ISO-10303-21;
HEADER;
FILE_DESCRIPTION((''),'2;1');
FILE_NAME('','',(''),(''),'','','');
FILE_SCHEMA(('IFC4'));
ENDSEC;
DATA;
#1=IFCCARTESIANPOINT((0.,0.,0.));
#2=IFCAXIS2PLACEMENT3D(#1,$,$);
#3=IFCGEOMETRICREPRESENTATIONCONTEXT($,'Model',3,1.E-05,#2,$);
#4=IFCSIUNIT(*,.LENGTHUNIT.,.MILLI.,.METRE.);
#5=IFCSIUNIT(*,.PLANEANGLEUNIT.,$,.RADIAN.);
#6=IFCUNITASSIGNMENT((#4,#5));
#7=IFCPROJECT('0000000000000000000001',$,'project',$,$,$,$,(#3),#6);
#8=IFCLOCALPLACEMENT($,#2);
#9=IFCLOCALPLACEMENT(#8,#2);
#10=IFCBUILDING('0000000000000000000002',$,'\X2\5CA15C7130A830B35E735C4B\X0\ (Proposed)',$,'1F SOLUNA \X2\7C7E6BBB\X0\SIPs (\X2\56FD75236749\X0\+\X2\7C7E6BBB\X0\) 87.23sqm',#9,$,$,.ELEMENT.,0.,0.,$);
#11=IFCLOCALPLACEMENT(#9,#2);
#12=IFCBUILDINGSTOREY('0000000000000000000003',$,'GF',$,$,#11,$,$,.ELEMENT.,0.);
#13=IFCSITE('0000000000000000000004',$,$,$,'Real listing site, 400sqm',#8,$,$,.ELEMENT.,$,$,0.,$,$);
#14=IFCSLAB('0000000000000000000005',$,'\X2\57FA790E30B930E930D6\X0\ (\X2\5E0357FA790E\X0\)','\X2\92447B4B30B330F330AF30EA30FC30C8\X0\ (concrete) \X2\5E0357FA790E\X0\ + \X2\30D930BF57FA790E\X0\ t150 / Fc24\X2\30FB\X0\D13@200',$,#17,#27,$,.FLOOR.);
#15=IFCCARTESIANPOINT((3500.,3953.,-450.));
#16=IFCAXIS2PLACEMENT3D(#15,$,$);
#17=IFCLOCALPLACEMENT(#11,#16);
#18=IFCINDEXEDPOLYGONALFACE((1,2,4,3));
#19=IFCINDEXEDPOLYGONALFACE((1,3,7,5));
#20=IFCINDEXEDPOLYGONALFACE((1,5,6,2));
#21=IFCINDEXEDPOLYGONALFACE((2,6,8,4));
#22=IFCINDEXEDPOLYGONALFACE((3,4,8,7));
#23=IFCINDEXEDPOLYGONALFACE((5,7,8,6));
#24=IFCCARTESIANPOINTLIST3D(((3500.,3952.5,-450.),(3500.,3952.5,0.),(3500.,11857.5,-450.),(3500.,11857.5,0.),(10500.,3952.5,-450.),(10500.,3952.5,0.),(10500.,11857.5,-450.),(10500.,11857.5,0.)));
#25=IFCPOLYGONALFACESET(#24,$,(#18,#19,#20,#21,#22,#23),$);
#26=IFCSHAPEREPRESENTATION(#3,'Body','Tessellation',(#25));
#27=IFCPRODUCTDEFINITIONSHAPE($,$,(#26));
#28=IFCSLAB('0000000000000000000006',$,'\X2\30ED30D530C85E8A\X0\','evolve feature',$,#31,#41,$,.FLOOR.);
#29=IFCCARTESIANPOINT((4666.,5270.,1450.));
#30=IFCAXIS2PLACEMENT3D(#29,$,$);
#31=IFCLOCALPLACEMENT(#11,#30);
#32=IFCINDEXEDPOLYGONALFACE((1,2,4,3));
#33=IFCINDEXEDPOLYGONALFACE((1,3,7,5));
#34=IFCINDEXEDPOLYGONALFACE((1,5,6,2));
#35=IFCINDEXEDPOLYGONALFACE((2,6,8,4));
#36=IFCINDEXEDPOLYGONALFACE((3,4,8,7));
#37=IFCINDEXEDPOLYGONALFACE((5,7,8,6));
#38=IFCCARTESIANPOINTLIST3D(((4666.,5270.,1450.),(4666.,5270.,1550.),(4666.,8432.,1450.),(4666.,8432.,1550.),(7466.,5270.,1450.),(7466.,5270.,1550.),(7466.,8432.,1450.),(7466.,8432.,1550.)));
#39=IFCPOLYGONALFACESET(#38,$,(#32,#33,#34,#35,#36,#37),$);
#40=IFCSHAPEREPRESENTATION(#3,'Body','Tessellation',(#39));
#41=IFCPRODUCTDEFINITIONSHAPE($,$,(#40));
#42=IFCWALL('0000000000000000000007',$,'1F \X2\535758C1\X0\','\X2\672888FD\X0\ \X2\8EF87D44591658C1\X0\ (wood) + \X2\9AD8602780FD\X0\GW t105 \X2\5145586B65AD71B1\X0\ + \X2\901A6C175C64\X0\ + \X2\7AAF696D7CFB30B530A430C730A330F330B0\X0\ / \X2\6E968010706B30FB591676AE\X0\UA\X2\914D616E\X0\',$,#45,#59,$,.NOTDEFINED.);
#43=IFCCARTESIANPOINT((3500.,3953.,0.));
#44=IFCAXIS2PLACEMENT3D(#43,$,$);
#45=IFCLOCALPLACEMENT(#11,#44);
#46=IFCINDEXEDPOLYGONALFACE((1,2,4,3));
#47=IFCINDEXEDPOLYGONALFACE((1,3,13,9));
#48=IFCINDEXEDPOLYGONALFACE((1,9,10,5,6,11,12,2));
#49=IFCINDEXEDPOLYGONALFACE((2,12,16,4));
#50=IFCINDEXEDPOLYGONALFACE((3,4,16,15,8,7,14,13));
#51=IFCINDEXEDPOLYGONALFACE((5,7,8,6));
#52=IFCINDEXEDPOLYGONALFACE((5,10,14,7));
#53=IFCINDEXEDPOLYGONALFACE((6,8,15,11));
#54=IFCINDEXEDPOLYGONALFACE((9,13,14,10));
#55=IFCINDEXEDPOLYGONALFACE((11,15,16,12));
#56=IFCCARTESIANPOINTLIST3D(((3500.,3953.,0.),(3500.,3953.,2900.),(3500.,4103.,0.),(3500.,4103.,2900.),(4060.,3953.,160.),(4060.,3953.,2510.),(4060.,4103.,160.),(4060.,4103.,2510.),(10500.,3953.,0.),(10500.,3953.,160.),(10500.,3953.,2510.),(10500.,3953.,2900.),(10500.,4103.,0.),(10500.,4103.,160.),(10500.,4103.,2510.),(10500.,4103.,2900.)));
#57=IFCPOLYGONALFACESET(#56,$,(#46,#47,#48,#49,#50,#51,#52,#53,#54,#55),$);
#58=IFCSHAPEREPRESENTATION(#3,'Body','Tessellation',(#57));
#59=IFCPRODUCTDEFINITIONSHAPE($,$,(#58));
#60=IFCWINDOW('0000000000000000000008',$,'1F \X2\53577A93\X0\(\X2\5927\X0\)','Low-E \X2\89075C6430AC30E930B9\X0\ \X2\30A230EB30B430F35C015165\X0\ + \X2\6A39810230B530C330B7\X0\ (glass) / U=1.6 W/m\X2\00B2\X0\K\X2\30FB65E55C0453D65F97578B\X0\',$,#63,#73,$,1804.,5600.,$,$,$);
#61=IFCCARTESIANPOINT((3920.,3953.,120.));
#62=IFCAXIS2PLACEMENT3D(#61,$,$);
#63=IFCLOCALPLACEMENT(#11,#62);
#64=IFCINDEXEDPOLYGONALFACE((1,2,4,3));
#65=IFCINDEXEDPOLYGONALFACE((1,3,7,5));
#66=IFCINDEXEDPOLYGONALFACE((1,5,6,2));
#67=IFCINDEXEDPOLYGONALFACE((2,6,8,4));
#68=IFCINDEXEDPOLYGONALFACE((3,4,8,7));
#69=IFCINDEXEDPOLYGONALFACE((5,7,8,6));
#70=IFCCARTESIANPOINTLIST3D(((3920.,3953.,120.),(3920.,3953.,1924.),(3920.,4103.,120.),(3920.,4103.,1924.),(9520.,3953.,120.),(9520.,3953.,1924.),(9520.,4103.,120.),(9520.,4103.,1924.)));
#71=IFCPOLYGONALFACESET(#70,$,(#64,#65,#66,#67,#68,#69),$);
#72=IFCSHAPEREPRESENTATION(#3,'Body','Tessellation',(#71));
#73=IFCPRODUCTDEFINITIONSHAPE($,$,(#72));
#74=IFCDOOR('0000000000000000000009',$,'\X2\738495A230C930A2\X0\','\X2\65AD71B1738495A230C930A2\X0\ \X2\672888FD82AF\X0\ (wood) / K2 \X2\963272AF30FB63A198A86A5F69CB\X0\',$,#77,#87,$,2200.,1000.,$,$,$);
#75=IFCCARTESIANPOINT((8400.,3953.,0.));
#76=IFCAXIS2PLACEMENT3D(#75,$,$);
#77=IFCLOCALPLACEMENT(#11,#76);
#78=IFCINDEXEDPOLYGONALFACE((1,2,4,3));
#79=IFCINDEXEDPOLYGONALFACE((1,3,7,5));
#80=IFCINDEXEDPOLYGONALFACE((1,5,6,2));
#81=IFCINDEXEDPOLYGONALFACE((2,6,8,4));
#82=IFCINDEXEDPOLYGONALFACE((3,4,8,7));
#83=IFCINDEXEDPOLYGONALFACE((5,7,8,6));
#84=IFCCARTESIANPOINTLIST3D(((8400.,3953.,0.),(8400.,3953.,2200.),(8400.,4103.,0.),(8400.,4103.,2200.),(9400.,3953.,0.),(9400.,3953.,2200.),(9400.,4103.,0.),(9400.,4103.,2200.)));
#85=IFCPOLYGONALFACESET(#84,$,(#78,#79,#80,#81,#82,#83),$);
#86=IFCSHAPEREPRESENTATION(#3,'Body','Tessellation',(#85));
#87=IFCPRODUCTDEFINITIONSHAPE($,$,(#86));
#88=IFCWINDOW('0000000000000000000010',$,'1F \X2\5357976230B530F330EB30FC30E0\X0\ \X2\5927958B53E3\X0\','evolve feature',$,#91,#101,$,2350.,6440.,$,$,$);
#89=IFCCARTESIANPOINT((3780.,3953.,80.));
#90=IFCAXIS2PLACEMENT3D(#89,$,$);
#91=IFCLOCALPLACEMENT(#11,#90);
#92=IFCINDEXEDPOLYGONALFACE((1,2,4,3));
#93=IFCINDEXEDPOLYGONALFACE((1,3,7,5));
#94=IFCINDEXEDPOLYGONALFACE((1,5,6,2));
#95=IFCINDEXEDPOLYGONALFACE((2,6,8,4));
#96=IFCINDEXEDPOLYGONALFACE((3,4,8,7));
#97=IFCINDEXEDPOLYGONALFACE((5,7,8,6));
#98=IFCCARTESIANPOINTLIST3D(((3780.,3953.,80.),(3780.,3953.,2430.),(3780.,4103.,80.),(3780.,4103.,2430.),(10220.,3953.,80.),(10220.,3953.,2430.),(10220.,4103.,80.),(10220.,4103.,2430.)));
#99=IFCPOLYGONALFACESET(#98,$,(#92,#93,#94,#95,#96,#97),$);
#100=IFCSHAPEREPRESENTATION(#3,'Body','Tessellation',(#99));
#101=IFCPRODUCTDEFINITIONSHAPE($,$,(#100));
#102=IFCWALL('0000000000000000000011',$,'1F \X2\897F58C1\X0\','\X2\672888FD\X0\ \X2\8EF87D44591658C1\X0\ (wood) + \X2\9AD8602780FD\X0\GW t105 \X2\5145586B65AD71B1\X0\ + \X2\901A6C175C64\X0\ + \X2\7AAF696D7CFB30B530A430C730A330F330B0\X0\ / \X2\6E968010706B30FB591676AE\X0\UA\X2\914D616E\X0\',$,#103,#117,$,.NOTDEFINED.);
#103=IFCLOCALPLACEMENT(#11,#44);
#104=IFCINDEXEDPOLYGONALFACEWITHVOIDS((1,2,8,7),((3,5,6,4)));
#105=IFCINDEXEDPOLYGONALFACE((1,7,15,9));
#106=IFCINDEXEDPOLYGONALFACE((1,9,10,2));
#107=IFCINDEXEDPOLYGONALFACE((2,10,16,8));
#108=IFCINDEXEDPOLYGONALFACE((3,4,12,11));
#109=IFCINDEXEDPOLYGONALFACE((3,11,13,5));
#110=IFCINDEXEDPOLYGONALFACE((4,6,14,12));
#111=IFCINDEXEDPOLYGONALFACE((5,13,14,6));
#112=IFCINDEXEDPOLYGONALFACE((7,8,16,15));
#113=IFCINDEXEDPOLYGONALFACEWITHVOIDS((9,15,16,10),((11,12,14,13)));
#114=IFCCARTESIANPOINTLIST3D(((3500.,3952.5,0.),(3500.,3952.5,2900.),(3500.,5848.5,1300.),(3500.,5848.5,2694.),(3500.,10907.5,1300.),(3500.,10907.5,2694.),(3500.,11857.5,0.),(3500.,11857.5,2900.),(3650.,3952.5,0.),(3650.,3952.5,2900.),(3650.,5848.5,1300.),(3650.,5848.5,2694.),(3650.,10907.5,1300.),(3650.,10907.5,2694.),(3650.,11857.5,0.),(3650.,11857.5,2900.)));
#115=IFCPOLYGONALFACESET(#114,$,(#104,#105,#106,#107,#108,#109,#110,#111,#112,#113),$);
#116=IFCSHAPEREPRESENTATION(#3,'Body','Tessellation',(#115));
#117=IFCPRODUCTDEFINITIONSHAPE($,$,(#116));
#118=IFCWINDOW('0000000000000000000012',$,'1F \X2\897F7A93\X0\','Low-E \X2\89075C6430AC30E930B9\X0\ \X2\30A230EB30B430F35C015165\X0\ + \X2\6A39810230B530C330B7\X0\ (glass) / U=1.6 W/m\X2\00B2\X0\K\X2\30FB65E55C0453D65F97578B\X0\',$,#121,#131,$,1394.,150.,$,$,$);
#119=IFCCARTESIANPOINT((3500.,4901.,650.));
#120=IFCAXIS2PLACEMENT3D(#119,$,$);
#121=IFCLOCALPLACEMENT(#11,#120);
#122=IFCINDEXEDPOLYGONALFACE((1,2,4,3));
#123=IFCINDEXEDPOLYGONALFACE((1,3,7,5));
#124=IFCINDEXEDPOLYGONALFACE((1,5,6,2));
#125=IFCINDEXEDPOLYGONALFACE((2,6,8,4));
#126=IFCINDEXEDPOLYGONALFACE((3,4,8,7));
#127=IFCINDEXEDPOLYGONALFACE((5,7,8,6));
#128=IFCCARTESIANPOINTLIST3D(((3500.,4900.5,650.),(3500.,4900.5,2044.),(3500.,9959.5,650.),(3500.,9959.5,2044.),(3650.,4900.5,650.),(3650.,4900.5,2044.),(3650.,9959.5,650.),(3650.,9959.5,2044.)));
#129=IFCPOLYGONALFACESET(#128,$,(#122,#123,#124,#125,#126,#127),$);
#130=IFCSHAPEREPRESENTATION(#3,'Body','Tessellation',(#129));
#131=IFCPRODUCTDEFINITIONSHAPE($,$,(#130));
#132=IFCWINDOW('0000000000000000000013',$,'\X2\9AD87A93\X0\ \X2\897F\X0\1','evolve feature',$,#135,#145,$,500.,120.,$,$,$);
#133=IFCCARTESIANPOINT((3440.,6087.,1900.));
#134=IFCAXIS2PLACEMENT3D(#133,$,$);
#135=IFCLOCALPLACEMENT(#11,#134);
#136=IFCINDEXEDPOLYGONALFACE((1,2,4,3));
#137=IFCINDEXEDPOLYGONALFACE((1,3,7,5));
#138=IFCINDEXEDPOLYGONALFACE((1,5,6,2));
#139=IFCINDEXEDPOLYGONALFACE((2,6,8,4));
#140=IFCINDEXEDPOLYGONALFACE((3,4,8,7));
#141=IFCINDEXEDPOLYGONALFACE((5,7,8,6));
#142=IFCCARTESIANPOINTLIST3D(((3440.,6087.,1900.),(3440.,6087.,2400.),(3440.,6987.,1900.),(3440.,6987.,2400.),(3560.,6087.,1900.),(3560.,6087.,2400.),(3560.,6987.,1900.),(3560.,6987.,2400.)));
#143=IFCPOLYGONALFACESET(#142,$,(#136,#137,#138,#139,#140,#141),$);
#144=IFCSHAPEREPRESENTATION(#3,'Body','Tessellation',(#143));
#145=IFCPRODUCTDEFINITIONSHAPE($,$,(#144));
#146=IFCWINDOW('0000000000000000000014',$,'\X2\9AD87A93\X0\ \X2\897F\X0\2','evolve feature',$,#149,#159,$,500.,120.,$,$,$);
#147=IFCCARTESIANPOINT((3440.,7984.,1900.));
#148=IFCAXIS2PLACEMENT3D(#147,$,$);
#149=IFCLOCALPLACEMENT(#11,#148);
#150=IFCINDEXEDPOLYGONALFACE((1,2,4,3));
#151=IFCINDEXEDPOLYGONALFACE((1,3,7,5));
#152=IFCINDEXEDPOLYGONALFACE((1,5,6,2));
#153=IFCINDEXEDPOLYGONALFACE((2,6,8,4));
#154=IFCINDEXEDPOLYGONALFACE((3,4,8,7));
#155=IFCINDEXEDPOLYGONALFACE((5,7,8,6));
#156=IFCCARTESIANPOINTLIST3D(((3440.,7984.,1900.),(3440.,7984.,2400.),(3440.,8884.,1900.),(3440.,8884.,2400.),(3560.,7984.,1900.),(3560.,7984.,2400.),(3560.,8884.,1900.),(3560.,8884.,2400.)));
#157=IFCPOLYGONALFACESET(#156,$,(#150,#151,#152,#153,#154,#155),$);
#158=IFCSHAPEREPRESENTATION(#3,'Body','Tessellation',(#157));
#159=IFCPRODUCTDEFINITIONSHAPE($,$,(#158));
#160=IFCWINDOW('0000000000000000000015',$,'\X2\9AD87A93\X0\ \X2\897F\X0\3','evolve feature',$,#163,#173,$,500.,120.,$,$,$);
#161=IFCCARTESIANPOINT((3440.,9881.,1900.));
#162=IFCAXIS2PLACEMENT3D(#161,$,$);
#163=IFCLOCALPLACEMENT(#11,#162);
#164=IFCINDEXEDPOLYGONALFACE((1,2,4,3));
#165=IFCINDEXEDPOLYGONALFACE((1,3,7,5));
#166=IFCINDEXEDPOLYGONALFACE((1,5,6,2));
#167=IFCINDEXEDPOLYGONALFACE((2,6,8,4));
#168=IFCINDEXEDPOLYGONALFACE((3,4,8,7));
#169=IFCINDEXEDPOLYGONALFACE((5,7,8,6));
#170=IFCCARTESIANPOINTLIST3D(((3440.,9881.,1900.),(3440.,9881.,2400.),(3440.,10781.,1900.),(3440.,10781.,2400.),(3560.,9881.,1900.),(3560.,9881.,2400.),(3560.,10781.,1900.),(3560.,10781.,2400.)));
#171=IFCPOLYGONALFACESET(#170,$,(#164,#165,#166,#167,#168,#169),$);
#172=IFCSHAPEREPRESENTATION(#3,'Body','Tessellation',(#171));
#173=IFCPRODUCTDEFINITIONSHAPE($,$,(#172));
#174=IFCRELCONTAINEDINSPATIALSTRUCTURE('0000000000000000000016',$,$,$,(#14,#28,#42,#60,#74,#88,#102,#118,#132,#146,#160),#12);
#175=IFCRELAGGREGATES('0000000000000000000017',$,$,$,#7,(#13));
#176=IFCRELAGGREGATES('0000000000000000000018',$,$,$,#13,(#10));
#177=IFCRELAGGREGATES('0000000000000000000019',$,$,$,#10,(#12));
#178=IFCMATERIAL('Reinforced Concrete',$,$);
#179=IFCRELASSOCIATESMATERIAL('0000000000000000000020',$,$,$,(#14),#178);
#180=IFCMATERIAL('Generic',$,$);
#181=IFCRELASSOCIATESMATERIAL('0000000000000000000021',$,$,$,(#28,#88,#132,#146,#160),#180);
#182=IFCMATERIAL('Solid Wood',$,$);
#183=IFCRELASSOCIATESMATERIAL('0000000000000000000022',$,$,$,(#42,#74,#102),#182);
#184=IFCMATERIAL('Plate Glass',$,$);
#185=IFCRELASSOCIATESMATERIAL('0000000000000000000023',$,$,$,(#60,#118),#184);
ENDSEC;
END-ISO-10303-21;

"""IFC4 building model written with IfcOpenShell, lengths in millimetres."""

from ifc_helpers import new_model, si_unit, frame, frame_2d, origin, place, context, project, spatial, rectangle, extrude, material, element, fill, save


model = new_model("IFC4")

# Units and contexts
model_context = context("Model", 3, precision=1e-05, world=origin())
ifc_project = project(units=[si_unit("LENGTHUNIT", "METRE", prefix="MILLI"), si_unit("PLANEANGLEUNIT", "RADIAN")], contexts=[model_context])

# Site, building, storey
site_placement = place(None, origin())
site = spatial("IfcSite", under=ifc_project, at=site_placement, ObjectType="Real listing site, 400sqm", CompositionType="ELEMENT", RefElevation=0.0)
building_placement = place(site_placement, origin())
building = spatial("IfcBuilding", under=site, at=building_placement, Name="岡山エコ平屋 (Proposed)", ObjectType="1F SOLUNA 籾殻SIPs (国産杉+籾殻) 87.23sqm", CompositionType="ELEMENT", ElevationOfRefHeight=0.0, ElevationOfTerrain=0.0)
storey_placement = place(building_placement, origin())
storey = spatial("IfcBuildingStorey", under=building, at=storey_placement, Name="GF", CompositionType="ELEMENT", Elevation=0.0)

# Slabs
ifc_material_1 = material(Name="Reinforced Concrete")
slab_1_placement = place(storey_placement, frame((3500.0, 3953.0, -450.0)))
element("IfcSlab", 1, at=slab_1_placement, inside=storey, material=ifc_material_1, Name="基礎スラブ (布基礎)", Description="鉄筋コンクリート (concrete) 布基礎 + ベタ基礎 t150 / Fc24・D13@200", PredefinedType="FLOOR", context=model_context, shape_type="SweptSolid", body=[
    extrude(rectangle(XDim=7000.0, YDim=7905.0, at=frame_2d((3500.0, 3952.0))), frame((3500.0, 3953.0, -450.0)), (0.0, 0.0, 1.0), 450.0),
])
ifc_material_2 = material(Name="Solid Wood")
ifc_material_3 = material(Name="Generic")
slab_2_placement = place(storey_placement, frame((4666.0, 5270.0, 1450.0)))
element("IfcSlab", 2, at=slab_2_placement, inside=storey, material=ifc_material_3, Name="ロフト床", Description="evolve feature", PredefinedType="FLOOR", context=model_context, shape_type="SweptSolid", body=[
    extrude(rectangle(XDim=2800.0, YDim=3162.0, at=frame_2d((1400.0, 1581.0))), frame((4666.0, 5270.0, 1450.0)), (0.0, 0.0, 1.0), 100.0),
])

# Wall, openings, windows, door
wall_1_placement = place(storey_placement, frame((3500.0, 3953.0, 0.0)))
wall_1 = element("IfcWall", 3, at=wall_1_placement, inside=storey, material=ifc_material_2, Name="1F 南壁", Description="木製 軸組外壁 (wood) + 高性能GW t105 充填断熱 + 通気層 + 窯業系サイディング / 準耐火・外皮UA配慮", PredefinedType="NOTDEFINED", context=model_context, shape_type="SweptSolid", body=[
    extrude(rectangle(XDim=7000.0, YDim=150.0, at=frame_2d((3500.0, 75.0))), frame((3500.0, 3953.0, 0.0)), (0.0, 0.0, 1.0), 2900.0),
])
opening_1_placement = place(storey_placement, frame((3920.0, 3953.0, 120.0)))
opening_1 = element("IfcOpeningElement", 4, at=opening_1_placement, cuts=wall_1, PredefinedType="NOTDEFINED", context=model_context, shape_type="SweptSolid", body=[
    extrude(rectangle(XDim=5600.0, YDim=150.0, at=frame_2d((2800.0, 75.0))), frame((3920.0, 3953.0, 120.0)), (0.0, 0.0, 1.0), 1804.0),
])
opening_2_placement = place(storey_placement, frame((8400.0, 3953.0, 0.0)))
opening_2 = element("IfcOpeningElement", 5, at=opening_2_placement, cuts=wall_1, PredefinedType="NOTDEFINED", context=model_context, shape_type="SweptSolid", body=[
    extrude(rectangle(XDim=1000.0, YDim=150.0, at=frame_2d((500.0, 75.0))), frame((8400.0, 3953.0, 0.0)), (0.0, 0.0, 1.0), 2200.0),
])
opening_3_placement = place(storey_placement, frame((3780.0, 3953.0, 80.0)))
opening_3 = element("IfcOpeningElement", 6, at=opening_3_placement, cuts=wall_1, PredefinedType="NOTDEFINED", context=model_context, shape_type="SweptSolid", body=[
    extrude(rectangle(XDim=6440.0, YDim=150.0, at=frame_2d((3220.0, 75.0))), frame((3780.0, 3953.0, 80.0)), (0.0, 0.0, 1.0), 2350.0),
])
ifc_material_4 = material(Name="Plate Glass")
window_1_placement = place(storey_placement, frame((3920.0, 3953.0, 120.0)))
window_1 = element("IfcWindow", 7, at=window_1_placement, inside=storey, material=ifc_material_4, Name="1F 南窓(大)", Description="Low-E 複層ガラス アルゴン封入 + 樹脂サッシ (glass) / U=1.6 W/m²K・日射取得型", OverallHeight=1804.0, OverallWidth=5600.0, context=model_context, shape_type="SweptSolid", body=[
    extrude(rectangle(XDim=5600.0, YDim=150.0, at=frame_2d((2800.0, 75.0))), frame((3920.0, 3953.0, 120.0)), (0.0, 0.0, 1.0), 1804.0),
])
fill(opening_1, window_1)
door_placement = place(storey_placement, frame((8400.0, 3953.0, 0.0)))
door = element("IfcDoor", 8, at=door_placement, inside=storey, material=ifc_material_2, Name="玄関ドア", Description="断熱玄関ドア 木製芯 (wood) / K2 防犯・採風機構", OverallHeight=2200.0, OverallWidth=1000.0, context=model_context, shape_type="SweptSolid", body=[
    extrude(rectangle(XDim=1000.0, YDim=150.0, at=frame_2d((500.0, 75.0))), frame((8400.0, 3953.0, 0.0)), (0.0, 0.0, 1.0), 2200.0),
])
fill(opening_2, door)
window_2_placement = place(storey_placement, frame((3780.0, 3953.0, 80.0)))
window_2 = element("IfcWindow", 9, at=window_2_placement, inside=storey, material=ifc_material_3, Name="1F 南面サンルーム 大開口", Description="evolve feature", OverallHeight=2350.0, OverallWidth=6440.0, context=model_context, shape_type="SweptSolid", body=[
    extrude(rectangle(XDim=6440.0, YDim=150.0, at=frame_2d((3220.0, 75.0))), frame((3780.0, 3953.0, 80.0)), (0.0, 0.0, 1.0), 2350.0),
])
fill(opening_3, window_2)

# Wall, openings, windows
wall_2_placement = place(storey_placement, frame((3500.0, 3953.0, 0.0)))
wall_2 = element("IfcWall", 10, at=wall_2_placement, inside=storey, material=ifc_material_2, Name="1F 西壁", Description="木製 軸組外壁 (wood) + 高性能GW t105 充填断熱 + 通気層 + 窯業系サイディング / 準耐火・外皮UA配慮", PredefinedType="NOTDEFINED", context=model_context, shape_type="SweptSolid", body=[
    extrude(rectangle(XDim=150.0, YDim=7905.0, at=frame_2d((75.0, 3952.0))), frame((3500.0, 3953.0, 0.0)), (0.0, 0.0, 1.0), 2900.0),
])
opening_4_placement = place(storey_placement, frame((3500.0, 4901.0, 650.0)))
opening_4 = element("IfcOpeningElement", 11, at=opening_4_placement, cuts=wall_2, PredefinedType="NOTDEFINED", context=model_context, shape_type="SweptSolid", body=[
    extrude(rectangle(XDim=150.0, YDim=5059.0, at=frame_2d((75.0, 2529.0))), frame((3500.0, 4901.0, 650.0)), (0.0, 0.0, 1.0), 1394.0),
])
opening_5_placement = place(storey_placement, frame((3440.0, 6087.0, 1900.0)))
opening_5 = element("IfcOpeningElement", 12, at=opening_5_placement, cuts=wall_2, PredefinedType="NOTDEFINED", context=model_context, shape_type="SweptSolid", body=[
    extrude(rectangle(XDim=120.0, YDim=900.0, at=frame_2d((60.0, 450.0))), frame((3440.0, 6087.0, 1900.0)), (0.0, 0.0, 1.0), 500.0),
])
opening_6_placement = place(storey_placement, frame((3440.0, 7984.0, 1900.0)))
opening_6 = element("IfcOpeningElement", 13, at=opening_6_placement, cuts=wall_2, PredefinedType="NOTDEFINED", context=model_context, shape_type="SweptSolid", body=[
    extrude(rectangle(XDim=120.0, YDim=900.0, at=frame_2d((60.0, 450.0))), frame((3440.0, 7984.0, 1900.0)), (0.0, 0.0, 1.0), 500.0),
])
opening_7_placement = place(storey_placement, frame((3440.0, 9881.0, 1900.0)))
opening_7 = element("IfcOpeningElement", 14, at=opening_7_placement, cuts=wall_2, PredefinedType="NOTDEFINED", context=model_context, shape_type="SweptSolid", body=[
    extrude(rectangle(XDim=120.0, YDim=900.0, at=frame_2d((60.0, 450.0))), frame((3440.0, 9881.0, 1900.0)), (0.0, 0.0, 1.0), 500.0),
])
window_3_placement = place(storey_placement, frame((3500.0, 4901.0, 650.0)))
window_3 = element("IfcWindow", 15, at=window_3_placement, inside=storey, material=ifc_material_4, Name="1F 西窓", Description="Low-E 複層ガラス アルゴン封入 + 樹脂サッシ (glass) / U=1.6 W/m²K・日射取得型", OverallHeight=1394.0, OverallWidth=150.0, context=model_context, shape_type="SweptSolid", body=[
    extrude(rectangle(XDim=150.0, YDim=5059.0, at=frame_2d((75.0, 2529.0))), frame((3500.0, 4901.0, 650.0)), (0.0, 0.0, 1.0), 1394.0),
])
fill(opening_4, window_3)
window_4_placement = place(storey_placement, frame((3440.0, 6087.0, 1900.0)))
window_4 = element("IfcWindow", 16, at=window_4_placement, inside=storey, material=ifc_material_3, Name="高窓 西1", Description="evolve feature", OverallHeight=500.0, OverallWidth=120.0, context=model_context, shape_type="SweptSolid", body=[
    extrude(rectangle(XDim=120.0, YDim=900.0, at=frame_2d((60.0, 450.0))), frame((3440.0, 6087.0, 1900.0)), (0.0, 0.0, 1.0), 500.0),
])
fill(opening_5, window_4)
window_5_placement = place(storey_placement, frame((3440.0, 7984.0, 1900.0)))
window_5 = element("IfcWindow", 17, at=window_5_placement, inside=storey, material=ifc_material_3, Name="高窓 西2", Description="evolve feature", OverallHeight=500.0, OverallWidth=120.0, context=model_context, shape_type="SweptSolid", body=[
    extrude(rectangle(XDim=120.0, YDim=900.0, at=frame_2d((60.0, 450.0))), frame((3440.0, 7984.0, 1900.0)), (0.0, 0.0, 1.0), 500.0),
])
fill(opening_6, window_5)
window_6_placement = place(storey_placement, frame((3440.0, 9881.0, 1900.0)))
window_6 = element("IfcWindow", 18, at=window_6_placement, inside=storey, material=ifc_material_3, Name="高窓 西3", Description="evolve feature", OverallHeight=500.0, OverallWidth=120.0, context=model_context, shape_type="SweptSolid", body=[
    extrude(rectangle(XDim=120.0, YDim=900.0, at=frame_2d((60.0, 450.0))), frame((3440.0, 9881.0, 1900.0)), (0.0, 0.0, 1.0), 500.0),
])
fill(opening_7, window_6)

save(model, "model.ifc")
